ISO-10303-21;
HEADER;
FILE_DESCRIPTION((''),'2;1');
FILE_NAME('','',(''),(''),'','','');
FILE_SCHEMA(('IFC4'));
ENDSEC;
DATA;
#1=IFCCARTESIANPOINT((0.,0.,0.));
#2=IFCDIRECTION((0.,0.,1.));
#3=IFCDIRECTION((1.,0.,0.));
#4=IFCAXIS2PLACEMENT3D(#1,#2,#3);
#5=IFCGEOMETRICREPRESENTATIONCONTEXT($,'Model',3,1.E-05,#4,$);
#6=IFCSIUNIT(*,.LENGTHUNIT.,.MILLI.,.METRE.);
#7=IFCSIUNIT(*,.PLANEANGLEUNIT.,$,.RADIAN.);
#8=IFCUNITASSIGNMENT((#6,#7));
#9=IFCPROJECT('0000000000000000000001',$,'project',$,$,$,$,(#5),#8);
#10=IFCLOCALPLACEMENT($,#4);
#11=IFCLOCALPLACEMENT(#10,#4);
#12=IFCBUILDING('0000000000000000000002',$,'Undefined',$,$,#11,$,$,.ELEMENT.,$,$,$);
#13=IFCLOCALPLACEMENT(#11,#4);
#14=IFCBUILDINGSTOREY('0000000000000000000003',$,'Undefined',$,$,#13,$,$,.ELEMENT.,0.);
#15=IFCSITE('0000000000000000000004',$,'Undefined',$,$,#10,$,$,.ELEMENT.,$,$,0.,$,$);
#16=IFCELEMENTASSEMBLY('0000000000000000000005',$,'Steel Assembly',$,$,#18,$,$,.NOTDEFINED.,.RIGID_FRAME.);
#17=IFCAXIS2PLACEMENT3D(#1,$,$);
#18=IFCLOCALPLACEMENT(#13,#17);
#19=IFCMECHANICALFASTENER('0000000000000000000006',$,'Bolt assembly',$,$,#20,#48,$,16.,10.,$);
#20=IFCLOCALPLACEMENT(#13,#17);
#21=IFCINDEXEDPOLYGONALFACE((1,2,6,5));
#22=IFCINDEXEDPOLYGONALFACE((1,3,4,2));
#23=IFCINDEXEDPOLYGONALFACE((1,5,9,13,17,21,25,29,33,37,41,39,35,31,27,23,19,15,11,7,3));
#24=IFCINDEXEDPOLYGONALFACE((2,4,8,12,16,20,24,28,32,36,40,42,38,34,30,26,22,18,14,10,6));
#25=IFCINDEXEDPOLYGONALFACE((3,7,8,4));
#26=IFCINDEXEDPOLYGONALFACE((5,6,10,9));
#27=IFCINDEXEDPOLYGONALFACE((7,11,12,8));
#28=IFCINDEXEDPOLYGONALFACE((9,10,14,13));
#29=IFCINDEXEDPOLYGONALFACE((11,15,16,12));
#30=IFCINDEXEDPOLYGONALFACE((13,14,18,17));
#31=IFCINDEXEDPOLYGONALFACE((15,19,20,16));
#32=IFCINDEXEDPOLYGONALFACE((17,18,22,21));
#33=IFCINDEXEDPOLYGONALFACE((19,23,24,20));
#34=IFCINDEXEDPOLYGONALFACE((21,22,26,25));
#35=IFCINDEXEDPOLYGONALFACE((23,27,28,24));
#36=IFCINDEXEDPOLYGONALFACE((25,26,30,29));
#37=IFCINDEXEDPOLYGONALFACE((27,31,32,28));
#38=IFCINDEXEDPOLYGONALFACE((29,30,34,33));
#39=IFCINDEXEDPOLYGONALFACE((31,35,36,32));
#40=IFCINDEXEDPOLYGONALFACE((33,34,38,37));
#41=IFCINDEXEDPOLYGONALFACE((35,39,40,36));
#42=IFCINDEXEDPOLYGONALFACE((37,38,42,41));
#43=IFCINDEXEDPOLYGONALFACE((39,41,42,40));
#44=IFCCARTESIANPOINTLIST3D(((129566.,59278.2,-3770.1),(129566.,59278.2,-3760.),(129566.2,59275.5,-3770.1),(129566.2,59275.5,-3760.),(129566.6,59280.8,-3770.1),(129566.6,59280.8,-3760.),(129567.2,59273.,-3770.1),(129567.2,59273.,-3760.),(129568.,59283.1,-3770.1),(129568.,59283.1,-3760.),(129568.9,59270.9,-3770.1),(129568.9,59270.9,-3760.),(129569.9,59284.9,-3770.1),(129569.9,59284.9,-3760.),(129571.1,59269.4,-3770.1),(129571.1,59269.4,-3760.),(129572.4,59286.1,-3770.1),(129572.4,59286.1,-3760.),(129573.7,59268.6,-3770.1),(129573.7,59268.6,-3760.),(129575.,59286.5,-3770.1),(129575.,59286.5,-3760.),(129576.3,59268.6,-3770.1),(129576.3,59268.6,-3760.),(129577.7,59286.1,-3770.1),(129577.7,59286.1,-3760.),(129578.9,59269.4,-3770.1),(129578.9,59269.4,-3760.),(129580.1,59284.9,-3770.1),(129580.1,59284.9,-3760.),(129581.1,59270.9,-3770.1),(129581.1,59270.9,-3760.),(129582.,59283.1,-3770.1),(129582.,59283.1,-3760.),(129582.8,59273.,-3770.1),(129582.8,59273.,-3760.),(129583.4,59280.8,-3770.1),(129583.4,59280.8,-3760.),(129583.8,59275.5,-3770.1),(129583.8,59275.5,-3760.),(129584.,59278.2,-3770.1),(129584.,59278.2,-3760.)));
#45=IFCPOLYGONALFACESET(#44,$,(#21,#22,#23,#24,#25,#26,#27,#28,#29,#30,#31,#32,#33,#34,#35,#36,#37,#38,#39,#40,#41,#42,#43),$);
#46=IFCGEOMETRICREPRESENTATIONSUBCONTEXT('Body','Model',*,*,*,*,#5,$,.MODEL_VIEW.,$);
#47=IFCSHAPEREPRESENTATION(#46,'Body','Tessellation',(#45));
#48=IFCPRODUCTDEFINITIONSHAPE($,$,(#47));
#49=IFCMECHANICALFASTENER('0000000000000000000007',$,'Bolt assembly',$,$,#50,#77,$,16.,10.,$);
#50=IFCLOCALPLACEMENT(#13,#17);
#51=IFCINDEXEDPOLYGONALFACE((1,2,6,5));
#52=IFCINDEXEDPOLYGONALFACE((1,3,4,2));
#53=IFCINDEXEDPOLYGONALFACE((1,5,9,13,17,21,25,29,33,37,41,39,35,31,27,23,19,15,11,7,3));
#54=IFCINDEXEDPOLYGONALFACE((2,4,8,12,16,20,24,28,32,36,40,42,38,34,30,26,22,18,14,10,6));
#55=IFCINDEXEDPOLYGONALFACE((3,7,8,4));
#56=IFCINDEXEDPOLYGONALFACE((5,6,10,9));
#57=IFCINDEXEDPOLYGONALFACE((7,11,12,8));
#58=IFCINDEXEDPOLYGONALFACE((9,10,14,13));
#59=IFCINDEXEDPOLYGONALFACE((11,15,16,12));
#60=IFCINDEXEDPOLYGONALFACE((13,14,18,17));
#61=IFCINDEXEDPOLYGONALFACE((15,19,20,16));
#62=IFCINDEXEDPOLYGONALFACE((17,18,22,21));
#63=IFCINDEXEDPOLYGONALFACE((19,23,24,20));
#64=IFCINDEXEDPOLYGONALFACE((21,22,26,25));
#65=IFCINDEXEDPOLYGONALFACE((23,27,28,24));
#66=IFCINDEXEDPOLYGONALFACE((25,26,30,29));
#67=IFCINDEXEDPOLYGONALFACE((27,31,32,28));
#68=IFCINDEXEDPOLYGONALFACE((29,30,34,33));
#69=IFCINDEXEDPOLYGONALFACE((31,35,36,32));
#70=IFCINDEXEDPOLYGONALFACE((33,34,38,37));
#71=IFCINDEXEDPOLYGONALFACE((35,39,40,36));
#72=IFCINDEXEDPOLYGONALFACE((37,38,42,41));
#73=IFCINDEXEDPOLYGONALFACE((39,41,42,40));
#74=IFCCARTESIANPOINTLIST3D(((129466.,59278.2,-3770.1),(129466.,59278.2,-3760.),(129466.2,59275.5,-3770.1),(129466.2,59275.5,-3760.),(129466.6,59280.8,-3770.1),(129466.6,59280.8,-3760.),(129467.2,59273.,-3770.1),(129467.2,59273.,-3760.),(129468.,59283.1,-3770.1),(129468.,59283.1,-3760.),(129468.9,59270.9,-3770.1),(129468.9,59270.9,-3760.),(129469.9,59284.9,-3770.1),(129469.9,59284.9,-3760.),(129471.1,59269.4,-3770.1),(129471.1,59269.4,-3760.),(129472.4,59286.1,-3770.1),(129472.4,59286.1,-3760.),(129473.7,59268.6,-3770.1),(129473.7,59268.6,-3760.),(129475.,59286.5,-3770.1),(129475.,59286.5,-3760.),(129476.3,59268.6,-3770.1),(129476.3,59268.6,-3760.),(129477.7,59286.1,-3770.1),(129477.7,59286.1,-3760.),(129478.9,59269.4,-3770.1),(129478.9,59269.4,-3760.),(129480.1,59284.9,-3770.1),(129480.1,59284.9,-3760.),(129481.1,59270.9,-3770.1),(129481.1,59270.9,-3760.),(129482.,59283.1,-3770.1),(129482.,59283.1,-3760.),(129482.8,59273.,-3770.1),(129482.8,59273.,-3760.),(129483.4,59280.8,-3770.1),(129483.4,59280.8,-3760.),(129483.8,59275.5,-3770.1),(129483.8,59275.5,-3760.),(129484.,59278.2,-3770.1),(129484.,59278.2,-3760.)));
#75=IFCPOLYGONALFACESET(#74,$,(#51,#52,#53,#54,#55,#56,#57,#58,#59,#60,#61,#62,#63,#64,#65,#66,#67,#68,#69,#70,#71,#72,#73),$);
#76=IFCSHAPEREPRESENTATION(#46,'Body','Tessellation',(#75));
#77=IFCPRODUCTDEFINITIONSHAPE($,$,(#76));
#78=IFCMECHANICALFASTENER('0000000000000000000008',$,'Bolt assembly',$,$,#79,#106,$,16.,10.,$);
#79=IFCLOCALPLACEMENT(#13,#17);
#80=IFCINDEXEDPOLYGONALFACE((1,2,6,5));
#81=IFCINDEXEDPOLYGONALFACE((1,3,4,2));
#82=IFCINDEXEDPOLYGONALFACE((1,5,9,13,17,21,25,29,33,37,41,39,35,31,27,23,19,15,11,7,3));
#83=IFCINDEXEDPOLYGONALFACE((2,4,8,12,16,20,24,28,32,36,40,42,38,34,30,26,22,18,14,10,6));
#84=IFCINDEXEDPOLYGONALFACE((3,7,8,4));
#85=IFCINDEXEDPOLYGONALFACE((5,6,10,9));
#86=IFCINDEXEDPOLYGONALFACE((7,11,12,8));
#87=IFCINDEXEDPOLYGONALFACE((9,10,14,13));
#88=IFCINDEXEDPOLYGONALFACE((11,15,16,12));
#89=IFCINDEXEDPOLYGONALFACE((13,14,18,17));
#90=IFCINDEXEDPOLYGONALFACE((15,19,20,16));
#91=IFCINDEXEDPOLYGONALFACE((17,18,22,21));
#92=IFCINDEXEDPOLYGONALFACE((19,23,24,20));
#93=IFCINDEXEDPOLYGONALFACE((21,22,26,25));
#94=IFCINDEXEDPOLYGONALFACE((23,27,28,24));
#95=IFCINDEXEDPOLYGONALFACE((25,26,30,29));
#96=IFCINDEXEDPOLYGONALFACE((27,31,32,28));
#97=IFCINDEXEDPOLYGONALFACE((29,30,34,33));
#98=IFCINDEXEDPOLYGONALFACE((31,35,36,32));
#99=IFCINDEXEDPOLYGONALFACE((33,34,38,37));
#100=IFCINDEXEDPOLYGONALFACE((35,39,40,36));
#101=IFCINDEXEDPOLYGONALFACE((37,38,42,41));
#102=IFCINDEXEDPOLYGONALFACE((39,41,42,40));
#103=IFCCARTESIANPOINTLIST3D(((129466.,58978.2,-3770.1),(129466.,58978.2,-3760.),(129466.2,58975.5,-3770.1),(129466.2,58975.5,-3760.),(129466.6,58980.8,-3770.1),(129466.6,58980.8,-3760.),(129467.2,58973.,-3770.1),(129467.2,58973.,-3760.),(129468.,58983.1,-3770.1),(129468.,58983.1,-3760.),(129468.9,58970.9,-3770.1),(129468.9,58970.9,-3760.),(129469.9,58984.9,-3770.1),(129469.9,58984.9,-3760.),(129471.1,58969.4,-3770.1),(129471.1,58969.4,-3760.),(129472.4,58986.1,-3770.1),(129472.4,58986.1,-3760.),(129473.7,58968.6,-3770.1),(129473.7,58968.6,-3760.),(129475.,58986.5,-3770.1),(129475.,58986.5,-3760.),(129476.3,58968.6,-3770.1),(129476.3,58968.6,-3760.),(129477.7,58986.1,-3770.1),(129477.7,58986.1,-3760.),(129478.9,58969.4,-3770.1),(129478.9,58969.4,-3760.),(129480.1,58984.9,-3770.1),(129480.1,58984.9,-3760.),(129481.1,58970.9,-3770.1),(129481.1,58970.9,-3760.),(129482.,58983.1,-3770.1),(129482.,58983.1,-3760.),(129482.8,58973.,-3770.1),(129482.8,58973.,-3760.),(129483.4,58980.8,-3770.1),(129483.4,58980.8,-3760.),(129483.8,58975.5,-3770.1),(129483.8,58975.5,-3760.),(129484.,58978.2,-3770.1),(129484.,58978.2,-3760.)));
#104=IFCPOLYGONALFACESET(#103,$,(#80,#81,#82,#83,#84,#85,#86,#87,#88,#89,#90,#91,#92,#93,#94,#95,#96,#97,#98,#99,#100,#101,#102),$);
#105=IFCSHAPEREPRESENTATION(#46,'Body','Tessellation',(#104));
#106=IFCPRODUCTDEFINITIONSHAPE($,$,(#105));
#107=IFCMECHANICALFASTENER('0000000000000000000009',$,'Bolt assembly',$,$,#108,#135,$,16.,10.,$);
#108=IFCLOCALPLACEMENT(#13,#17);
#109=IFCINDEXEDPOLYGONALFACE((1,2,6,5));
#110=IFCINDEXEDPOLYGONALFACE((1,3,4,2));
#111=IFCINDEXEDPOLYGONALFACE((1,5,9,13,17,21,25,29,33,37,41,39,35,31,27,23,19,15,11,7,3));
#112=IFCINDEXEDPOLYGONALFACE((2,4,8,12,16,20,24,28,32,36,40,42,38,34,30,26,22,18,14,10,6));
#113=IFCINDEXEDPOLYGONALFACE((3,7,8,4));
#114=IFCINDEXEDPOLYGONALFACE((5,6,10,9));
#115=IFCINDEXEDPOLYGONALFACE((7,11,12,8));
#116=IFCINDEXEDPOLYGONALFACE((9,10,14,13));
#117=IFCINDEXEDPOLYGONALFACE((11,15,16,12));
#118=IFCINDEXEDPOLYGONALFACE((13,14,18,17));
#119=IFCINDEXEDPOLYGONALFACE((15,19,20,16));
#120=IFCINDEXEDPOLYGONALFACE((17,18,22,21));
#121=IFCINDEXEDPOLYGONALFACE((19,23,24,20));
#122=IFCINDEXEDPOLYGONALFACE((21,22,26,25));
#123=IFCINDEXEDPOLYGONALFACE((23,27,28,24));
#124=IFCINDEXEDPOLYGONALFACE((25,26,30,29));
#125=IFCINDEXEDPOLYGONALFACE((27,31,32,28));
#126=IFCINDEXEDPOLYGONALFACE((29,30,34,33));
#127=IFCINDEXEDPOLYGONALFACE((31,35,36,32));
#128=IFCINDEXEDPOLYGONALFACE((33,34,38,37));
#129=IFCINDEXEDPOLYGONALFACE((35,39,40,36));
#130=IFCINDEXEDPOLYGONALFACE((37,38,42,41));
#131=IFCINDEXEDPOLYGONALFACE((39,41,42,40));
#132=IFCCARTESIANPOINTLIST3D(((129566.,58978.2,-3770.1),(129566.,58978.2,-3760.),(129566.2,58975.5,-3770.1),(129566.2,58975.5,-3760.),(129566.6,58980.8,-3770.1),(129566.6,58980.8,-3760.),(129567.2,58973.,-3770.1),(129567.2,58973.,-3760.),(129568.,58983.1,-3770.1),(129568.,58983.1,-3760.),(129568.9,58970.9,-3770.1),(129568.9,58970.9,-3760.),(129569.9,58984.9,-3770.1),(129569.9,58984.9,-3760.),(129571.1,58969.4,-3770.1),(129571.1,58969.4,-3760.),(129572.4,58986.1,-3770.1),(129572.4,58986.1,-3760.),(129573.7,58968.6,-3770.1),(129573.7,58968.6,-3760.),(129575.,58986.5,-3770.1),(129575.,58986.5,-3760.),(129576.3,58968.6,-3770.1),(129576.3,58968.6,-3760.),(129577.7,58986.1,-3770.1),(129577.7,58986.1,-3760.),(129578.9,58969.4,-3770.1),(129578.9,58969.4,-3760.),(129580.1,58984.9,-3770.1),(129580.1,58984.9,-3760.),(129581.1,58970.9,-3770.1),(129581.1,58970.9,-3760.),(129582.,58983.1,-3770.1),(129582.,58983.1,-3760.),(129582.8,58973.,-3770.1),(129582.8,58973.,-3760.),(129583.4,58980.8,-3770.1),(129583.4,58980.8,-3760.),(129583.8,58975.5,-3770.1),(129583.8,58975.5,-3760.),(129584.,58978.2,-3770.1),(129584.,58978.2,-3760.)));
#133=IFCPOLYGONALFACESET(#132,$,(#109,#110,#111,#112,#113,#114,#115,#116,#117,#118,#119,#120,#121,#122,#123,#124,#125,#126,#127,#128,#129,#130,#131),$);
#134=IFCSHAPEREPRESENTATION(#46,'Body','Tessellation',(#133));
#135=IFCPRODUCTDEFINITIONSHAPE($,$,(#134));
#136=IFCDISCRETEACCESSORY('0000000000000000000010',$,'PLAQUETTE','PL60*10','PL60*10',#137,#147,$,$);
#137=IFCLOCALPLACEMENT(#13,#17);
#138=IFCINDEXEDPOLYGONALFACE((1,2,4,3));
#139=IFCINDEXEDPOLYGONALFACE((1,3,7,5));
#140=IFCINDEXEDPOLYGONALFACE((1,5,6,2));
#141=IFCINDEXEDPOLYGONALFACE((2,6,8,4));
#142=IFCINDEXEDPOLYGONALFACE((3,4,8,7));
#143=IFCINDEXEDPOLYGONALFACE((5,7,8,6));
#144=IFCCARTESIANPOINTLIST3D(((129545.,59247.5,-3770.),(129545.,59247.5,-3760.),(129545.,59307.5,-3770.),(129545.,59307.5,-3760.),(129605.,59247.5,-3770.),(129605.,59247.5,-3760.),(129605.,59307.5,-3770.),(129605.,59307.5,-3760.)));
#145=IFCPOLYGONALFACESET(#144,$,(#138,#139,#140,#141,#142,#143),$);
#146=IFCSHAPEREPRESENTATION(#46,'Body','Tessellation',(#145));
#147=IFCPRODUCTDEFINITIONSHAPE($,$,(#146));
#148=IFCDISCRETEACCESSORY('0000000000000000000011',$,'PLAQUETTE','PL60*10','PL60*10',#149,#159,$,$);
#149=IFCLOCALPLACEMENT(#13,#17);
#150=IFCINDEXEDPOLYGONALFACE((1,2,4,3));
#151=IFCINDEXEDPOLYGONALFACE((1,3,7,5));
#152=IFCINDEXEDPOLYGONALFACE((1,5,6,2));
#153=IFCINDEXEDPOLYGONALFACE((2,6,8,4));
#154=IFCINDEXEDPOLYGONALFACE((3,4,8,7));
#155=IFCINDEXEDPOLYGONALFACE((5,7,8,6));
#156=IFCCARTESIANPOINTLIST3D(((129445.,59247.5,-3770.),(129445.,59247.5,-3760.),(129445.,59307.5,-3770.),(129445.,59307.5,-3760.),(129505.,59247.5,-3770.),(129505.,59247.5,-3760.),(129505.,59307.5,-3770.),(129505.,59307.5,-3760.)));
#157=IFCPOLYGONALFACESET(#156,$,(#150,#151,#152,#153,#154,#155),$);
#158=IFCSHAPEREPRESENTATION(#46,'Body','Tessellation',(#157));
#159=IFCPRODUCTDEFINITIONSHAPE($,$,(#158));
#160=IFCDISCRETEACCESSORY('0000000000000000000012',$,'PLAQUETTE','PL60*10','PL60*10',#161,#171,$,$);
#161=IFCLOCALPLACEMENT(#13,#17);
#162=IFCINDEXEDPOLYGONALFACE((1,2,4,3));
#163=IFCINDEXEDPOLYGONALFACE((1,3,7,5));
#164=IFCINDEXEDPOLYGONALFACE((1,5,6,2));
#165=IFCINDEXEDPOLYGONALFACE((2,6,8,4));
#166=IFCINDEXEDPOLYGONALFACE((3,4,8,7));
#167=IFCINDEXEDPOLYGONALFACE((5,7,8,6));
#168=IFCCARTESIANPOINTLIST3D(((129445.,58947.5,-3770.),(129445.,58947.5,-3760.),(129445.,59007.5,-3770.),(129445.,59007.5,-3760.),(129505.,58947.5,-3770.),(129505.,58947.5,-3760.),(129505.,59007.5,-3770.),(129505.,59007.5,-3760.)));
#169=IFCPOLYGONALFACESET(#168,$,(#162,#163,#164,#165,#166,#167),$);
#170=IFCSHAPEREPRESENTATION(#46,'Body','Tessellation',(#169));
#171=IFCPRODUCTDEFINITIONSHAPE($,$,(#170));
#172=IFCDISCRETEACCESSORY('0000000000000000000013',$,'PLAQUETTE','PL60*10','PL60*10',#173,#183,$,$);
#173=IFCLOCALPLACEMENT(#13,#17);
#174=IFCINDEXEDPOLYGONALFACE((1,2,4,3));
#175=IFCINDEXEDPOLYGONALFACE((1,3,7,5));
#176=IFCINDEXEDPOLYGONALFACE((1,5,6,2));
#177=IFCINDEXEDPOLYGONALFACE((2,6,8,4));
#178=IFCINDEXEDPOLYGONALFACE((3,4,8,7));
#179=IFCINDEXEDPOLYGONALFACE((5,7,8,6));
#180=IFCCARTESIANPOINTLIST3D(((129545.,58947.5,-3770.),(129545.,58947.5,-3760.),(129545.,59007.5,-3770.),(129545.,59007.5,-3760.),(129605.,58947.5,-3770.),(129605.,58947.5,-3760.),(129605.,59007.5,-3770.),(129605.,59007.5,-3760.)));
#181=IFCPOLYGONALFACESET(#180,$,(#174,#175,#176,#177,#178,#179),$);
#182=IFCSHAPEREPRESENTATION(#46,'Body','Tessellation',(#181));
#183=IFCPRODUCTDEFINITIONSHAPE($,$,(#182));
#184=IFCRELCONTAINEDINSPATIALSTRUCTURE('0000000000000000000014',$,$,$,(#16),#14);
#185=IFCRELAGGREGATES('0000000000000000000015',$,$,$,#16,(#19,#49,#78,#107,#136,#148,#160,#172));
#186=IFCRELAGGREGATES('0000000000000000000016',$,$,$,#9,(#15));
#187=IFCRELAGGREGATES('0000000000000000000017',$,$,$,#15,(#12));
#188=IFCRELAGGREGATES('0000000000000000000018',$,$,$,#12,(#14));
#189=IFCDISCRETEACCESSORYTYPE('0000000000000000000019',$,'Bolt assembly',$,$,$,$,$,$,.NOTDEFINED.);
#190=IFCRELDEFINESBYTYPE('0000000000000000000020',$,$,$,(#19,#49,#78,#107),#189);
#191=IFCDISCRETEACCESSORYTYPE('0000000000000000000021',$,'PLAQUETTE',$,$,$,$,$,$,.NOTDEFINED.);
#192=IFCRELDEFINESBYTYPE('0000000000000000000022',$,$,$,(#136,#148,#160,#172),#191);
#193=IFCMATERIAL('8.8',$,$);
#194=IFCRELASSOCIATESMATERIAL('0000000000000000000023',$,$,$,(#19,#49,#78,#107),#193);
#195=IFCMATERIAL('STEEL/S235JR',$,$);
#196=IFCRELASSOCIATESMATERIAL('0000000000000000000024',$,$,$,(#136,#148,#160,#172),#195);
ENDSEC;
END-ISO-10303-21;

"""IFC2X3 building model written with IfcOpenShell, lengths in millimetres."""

from ifc_helpers import new_model, si_unit, frame, origin_with_axes, origin_2d_with_axis, place, context, subcontext, project, spatial, polyline, circle, outline, extrude, source, transform, mapped, material, type_object, element, aggregate, save


model = new_model("IFC2X3")

# Units and contexts
model_context = context("Model", 3, precision=1e-05, world=origin_with_axes())
body_context = subcontext(model_context, "Body", "Model", "MODEL_VIEW")
ifc_project = project(units=[si_unit("LENGTHUNIT", "METRE", prefix="MILLI"), si_unit("PLANEANGLEUNIT", "RADIAN")], contexts=[model_context])

# Site, building, storey
site_placement = place(None, origin_with_axes())
site = spatial("IfcSite", under=ifc_project, at=site_placement, Name="Undefined", CompositionType="ELEMENT", RefElevation=0.0)
building_placement = place(site_placement, origin_with_axes())
building = spatial("IfcBuilding", under=site, at=building_placement, Name="Undefined", CompositionType="ELEMENT")
storey_placement = place(building_placement, origin_with_axes())
storey = spatial("IfcBuildingStorey", under=building, at=storey_placement, Name="Undefined", CompositionType="ELEMENT", Elevation=0.0)

# Shared definitions
ifc_material_1 = material(Name="STEEL/S235JR")

# Element assembly, mechanical fasteners, discrete accessories
assembly_1_placement = place(storey_placement, origin_with_axes())
assembly_1 = element("IfcElementAssembly", 1, at=assembly_1_placement, inside=storey, Name="Steel Assembly", AssemblyPlace="NOTDEFINED", PredefinedType="RIGID_FRAME")
ifc_material_2 = material(Name="8.8")
discrete_accessory_type_1 = type_object("IfcDiscreteAccessoryType", Name="Bolt assembly")
shared_shape_1 = source(origin_with_axes(), body_context, "Body", "SweptSolid", [
    extrude(circle(Radius=9.0, at=origin_2d_with_axis()), frame((0.0, 0.0, 0.0), z_axis=(0.0, 1.0, 0.0), x_axis=(1.0, 0.0, 0.0)), (0.0, 0.0, 1.0), 10.1),
])
mechanical_fastener_1_placement = place(assembly_1_placement, frame((129575.0, 59277.5, -3760.0), z_axis=(-1.0, 0.0, 0.0), x_axis=(0.0, 1.0, 0.0)))
mechanical_fastener_1 = element("IfcMechanicalFastener", 2, at=mechanical_fastener_1_placement, type_object=discrete_accessory_type_1, material=ifc_material_2, Name="Bolt assembly", NominalDiameter=16.0, NominalLength=10.0, context=body_context, shape_type="MappedRepresentation", body=[
    mapped(shared_shape_1, transform((0.0, 0.0, 0.0))),
])
mechanical_fastener_2_placement = place(assembly_1_placement, frame((129475.0, 59277.5, -3760.0), z_axis=(-1.0, 0.0, 0.0), x_axis=(0.0, 1.0, 0.0)))
mechanical_fastener_2 = element("IfcMechanicalFastener", 3, at=mechanical_fastener_2_placement, type_object=discrete_accessory_type_1, material=ifc_material_2, Name="Bolt assembly", NominalDiameter=16.0, NominalLength=10.0, context=body_context, shape_type="MappedRepresentation", body=[
    mapped(shared_shape_1, transform((0.0, 0.0, 0.0))),
])
mechanical_fastener_3_placement = place(assembly_1_placement, frame((129475.0, 58977.5, -3760.0), z_axis=(-1.0, 0.0, 0.0), x_axis=(0.0, 1.0, 0.0)))
mechanical_fastener_3 = element("IfcMechanicalFastener", 4, at=mechanical_fastener_3_placement, type_object=discrete_accessory_type_1, material=ifc_material_2, Name="Bolt assembly", NominalDiameter=16.0, NominalLength=10.0, context=body_context, shape_type="MappedRepresentation", body=[
    mapped(shared_shape_1, transform((0.0, 0.0, 0.0))),
])
mechanical_fastener_4_placement = place(assembly_1_placement, frame((129575.0, 58977.5, -3760.0), z_axis=(-1.0, 0.0, 0.0), x_axis=(0.0, 1.0, 0.0)))
mechanical_fastener_4 = element("IfcMechanicalFastener", 5, at=mechanical_fastener_4_placement, type_object=discrete_accessory_type_1, material=ifc_material_2, Name="Bolt assembly", NominalDiameter=16.0, NominalLength=10.0, context=body_context, shape_type="MappedRepresentation", body=[
    mapped(shared_shape_1, transform((0.0, 0.0, 0.0))),
])
discrete_accessory_type_2 = type_object("IfcDiscreteAccessoryType", Name="PLAQUETTE")
discrete_accessory_1_placement = place(assembly_1_placement, frame((129575.0, 59247.5, -3765.0), z_axis=(0.0, 0.0, -1.0), x_axis=(0.0, 1.0, 0.0)))
discrete_accessory_1 = element("IfcDiscreteAccessory", 6, at=discrete_accessory_1_placement, type_object=discrete_accessory_type_2, material=ifc_material_1, Name="PLAQUETTE", Description="PL60*10", ObjectType="PL60*10", context=body_context, shape_type="SweptSolid", body=[
    extrude(outline(polyline([(0.0, -30.0), (0.0, 30.0), (60.0, 30.0), (60.0, -30.0), (0.0, -30.0)])), frame((0.0, 0.0, -5.0), z_axis=(0.0, 0.0, 1.0), x_axis=(1.0, 0.0, 0.0)), (0.0, 0.0, 1.0), 10.0),
])
discrete_accessory_2_placement = place(assembly_1_placement, frame((129475.0, 59247.5, -3765.0), z_axis=(0.0, 0.0, -1.0), x_axis=(0.0, 1.0, 0.0)))
discrete_accessory_2 = element("IfcDiscreteAccessory", 7, at=discrete_accessory_2_placement, type_object=discrete_accessory_type_2, material=ifc_material_1, Name="PLAQUETTE", Description="PL60*10", ObjectType="PL60*10", context=body_context, shape_type="SweptSolid", body=[
    extrude(outline(polyline([(0.0, -30.0), (0.0, 30.0), (60.0, 30.0), (60.0, -30.0), (0.0, -30.0)])), frame((0.0, 0.0, -5.0), z_axis=(0.0, 0.0, 1.0), x_axis=(1.0, 0.0, 0.0)), (0.0, 0.0, 1.0), 10.0),
])
discrete_accessory_3_placement = place(assembly_1_placement, frame((129475.0, 58947.5, -3765.0), z_axis=(0.0, 0.0, -1.0), x_axis=(0.0, 1.0, 0.0)))
discrete_accessory_3 = element("IfcDiscreteAccessory", 8, at=discrete_accessory_3_placement, type_object=discrete_accessory_type_2, material=ifc_material_1, Name="PLAQUETTE", Description="PL60*10", ObjectType="PL60*10", context=body_context, shape_type="SweptSolid", body=[
    extrude(outline(polyline([(0.0, -30.0), (0.0, 30.0), (60.0, 30.0), (60.0, -30.0), (0.0, -30.0)])), frame((0.0, 0.0, -5.0), z_axis=(0.0, 0.0, 1.0), x_axis=(1.0, 0.0, 0.0)), (0.0, 0.0, 1.0), 10.0),
])
discrete_accessory_4_placement = place(assembly_1_placement, frame((129575.0, 58947.5, -3765.0), z_axis=(0.0, 0.0, -1.0), x_axis=(0.0, 1.0, 0.0)))
discrete_accessory_4 = element("IfcDiscreteAccessory", 9, at=discrete_accessory_4_placement, type_object=discrete_accessory_type_2, material=ifc_material_1, Name="PLAQUETTE", Description="PL60*10", ObjectType="PL60*10", context=body_context, shape_type="SweptSolid", body=[
    extrude(outline(polyline([(0.0, -30.0), (0.0, 30.0), (60.0, 30.0), (60.0, -30.0), (0.0, -30.0)])), frame((0.0, 0.0, -5.0), z_axis=(0.0, 0.0, 1.0), x_axis=(1.0, 0.0, 0.0)), (0.0, 0.0, 1.0), 10.0),
])

aggregate(assembly_1, [mechanical_fastener_1, mechanical_fastener_2, mechanical_fastener_3, mechanical_fastener_4, discrete_accessory_1, discrete_accessory_2, discrete_accessory_3, discrete_accessory_4])

save(model, "model.ifc")
